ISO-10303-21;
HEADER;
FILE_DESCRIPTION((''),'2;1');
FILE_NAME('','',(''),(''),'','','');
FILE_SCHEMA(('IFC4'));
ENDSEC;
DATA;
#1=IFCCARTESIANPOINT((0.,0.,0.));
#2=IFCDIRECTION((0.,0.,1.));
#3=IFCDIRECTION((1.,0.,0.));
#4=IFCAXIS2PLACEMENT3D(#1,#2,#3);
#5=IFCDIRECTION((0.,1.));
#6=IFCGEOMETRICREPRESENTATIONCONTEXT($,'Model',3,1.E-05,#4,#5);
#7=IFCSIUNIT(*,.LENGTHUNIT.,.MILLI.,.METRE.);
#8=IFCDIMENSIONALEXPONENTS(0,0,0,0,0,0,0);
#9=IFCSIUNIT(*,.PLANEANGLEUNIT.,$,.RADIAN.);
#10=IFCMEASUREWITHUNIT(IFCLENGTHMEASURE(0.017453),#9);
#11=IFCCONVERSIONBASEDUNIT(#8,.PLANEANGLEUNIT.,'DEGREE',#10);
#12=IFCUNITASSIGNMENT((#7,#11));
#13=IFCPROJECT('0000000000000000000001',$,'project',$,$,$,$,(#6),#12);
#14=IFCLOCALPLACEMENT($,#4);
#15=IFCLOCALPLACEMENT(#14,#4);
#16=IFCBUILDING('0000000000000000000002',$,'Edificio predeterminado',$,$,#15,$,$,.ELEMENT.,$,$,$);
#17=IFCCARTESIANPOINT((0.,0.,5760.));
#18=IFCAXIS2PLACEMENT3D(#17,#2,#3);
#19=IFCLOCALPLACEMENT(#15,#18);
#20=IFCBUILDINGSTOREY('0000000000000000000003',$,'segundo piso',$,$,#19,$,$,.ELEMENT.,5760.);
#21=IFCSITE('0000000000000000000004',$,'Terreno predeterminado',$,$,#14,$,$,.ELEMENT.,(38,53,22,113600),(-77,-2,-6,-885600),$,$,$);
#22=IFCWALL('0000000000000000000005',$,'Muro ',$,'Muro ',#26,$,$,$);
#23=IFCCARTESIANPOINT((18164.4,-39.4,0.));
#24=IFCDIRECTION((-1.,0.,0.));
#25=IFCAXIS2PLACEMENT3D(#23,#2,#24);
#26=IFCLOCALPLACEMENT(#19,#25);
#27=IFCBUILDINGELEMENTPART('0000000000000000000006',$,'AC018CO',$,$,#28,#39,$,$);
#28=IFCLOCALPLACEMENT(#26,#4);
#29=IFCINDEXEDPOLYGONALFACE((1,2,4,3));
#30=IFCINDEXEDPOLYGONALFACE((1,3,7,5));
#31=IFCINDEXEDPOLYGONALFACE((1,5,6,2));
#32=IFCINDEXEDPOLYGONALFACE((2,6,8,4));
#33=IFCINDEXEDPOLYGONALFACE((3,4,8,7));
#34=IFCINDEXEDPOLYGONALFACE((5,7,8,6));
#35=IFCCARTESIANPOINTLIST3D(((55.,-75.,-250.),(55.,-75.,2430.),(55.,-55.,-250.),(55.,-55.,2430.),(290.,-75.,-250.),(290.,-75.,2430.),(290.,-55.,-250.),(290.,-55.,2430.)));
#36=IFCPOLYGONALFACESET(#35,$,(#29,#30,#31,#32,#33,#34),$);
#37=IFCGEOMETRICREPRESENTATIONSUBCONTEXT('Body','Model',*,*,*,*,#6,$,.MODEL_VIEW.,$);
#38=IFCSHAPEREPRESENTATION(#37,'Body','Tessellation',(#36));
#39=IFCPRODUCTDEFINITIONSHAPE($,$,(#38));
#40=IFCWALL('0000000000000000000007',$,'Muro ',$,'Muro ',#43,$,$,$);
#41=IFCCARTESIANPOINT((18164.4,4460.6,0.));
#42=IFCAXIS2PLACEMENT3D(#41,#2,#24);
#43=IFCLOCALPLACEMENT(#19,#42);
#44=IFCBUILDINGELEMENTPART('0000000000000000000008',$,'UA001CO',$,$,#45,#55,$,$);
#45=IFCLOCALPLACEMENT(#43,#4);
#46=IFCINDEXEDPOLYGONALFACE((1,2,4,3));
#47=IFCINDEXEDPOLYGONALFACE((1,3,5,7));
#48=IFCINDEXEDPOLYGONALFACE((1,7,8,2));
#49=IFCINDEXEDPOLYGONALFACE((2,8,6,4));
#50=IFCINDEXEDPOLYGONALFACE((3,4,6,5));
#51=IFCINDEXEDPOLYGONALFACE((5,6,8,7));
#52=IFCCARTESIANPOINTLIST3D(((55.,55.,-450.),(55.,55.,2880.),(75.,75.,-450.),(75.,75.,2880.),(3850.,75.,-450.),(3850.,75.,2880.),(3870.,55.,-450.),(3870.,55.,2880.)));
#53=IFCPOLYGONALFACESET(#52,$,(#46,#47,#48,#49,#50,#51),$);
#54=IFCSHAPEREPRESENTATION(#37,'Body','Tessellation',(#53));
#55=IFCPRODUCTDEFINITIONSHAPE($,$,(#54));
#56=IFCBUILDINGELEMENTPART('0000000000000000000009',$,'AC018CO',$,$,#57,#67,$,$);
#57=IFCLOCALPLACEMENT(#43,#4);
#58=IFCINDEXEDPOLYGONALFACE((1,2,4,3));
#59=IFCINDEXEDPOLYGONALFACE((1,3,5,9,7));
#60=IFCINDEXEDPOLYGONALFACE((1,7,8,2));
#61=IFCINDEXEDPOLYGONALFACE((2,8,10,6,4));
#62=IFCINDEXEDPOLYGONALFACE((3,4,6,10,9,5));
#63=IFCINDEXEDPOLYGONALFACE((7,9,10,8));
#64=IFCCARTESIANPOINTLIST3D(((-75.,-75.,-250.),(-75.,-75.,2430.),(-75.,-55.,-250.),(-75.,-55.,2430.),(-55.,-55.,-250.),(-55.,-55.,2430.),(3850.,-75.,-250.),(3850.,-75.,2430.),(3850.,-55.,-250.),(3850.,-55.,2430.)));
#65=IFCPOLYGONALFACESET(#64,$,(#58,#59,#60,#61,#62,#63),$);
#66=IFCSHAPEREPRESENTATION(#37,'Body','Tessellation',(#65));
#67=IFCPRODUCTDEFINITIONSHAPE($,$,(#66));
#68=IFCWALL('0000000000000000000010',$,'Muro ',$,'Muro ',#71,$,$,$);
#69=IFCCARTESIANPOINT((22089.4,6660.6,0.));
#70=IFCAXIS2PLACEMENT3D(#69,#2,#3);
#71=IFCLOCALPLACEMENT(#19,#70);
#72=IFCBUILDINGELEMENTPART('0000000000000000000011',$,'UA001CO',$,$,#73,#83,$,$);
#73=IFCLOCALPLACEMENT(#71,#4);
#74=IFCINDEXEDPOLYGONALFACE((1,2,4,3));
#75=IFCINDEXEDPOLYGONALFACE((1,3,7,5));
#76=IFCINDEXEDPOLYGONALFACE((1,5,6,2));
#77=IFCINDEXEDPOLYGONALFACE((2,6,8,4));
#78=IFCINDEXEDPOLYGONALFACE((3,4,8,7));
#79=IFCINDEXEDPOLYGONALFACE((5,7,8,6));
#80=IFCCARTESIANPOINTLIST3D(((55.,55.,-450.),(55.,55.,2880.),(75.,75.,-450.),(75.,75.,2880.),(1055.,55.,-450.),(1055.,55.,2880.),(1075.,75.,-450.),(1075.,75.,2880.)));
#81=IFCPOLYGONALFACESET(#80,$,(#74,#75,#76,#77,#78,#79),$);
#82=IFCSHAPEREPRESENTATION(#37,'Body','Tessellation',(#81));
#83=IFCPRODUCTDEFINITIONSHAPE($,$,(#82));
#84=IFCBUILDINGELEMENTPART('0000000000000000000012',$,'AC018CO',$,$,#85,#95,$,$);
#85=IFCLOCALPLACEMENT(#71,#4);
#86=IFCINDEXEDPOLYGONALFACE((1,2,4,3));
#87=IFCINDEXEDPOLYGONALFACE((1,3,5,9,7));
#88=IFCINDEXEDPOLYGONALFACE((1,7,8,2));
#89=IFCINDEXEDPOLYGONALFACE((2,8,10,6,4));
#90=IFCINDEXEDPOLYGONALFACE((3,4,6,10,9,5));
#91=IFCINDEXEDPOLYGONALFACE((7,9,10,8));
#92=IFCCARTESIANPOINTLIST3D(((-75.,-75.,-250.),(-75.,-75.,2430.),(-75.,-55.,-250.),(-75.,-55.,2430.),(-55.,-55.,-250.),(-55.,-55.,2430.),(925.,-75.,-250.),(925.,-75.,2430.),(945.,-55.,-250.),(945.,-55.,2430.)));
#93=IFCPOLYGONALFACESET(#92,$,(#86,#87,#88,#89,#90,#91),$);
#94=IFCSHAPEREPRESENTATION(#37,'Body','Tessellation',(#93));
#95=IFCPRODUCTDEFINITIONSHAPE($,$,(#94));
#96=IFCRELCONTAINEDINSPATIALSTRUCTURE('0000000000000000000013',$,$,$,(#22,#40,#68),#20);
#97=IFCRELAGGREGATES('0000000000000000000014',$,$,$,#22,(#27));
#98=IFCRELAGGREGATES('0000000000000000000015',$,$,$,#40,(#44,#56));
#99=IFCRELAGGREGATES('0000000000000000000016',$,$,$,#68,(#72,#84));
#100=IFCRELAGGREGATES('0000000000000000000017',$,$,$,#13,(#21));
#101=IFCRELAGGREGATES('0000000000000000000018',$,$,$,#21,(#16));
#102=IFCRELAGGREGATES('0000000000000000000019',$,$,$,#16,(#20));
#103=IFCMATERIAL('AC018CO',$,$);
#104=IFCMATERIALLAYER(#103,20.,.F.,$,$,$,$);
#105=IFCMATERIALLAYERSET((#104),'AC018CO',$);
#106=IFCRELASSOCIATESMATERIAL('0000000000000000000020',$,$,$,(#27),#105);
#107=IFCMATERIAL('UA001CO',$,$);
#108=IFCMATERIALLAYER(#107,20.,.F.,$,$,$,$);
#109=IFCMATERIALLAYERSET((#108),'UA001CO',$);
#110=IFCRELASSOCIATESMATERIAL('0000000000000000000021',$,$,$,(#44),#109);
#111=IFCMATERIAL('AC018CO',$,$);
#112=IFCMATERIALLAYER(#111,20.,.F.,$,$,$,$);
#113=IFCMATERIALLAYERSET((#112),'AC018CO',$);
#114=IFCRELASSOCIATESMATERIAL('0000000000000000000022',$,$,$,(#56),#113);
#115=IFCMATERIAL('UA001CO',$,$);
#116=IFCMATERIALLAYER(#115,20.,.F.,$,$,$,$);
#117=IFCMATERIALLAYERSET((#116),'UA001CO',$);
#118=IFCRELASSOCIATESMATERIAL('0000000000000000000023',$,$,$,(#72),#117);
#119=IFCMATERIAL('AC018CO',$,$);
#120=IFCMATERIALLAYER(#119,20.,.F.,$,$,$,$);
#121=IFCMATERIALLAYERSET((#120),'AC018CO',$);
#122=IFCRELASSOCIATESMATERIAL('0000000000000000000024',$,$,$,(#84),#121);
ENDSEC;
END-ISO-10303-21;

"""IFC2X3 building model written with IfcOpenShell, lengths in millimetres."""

from ifc_helpers import new_model, entity, si_unit, converted_unit, direction, frame, origin_with_axes, place, context, subcontext, project, spatial, polyline, outline, extrude, material, layer, layer_set, layer_usage, element, aggregate, save


model = new_model("IFC2X3")

# Units and contexts
model_context = context("Model", 3, precision=1e-05, world=origin_with_axes(), true_north=direction((0.0, 1.0)))
body_context = subcontext(model_context, "Body", "Model", "MODEL_VIEW")
ifc_project = project(units=[si_unit("LENGTHUNIT", "METRE", prefix="MILLI"), converted_unit("PLANEANGLEUNIT", "DEGREE", entity("IfcLengthMeasure", 0.017453), si_unit("PLANEANGLEUNIT", "RADIAN"), dimensions=[0, 0, 0, 0, 0, 0, 0])], contexts=[model_context])

# Site, building, storey
site_placement = place(None, origin_with_axes())
site = spatial("IfcSite", under=ifc_project, at=site_placement, Name="Terreno predeterminado", CompositionType="ELEMENT", RefLatitude=(38, 53, 22, 113600), RefLongitude=(-77, -2, -6, -885600))
building_placement = place(site_placement, origin_with_axes())
building = spatial("IfcBuilding", under=site, at=building_placement, Name="Edificio predeterminado", CompositionType="ELEMENT")
storey_placement = place(building_placement, frame((0.0, 0.0, 5760.0), z_axis=(0.0, 0.0, 1.0), x_axis=(1.0, 0.0, 0.0)))
storey = spatial("IfcBuildingStorey", under=building, at=storey_placement, Name="segundo piso", CompositionType="ELEMENT", Elevation=5760.0)

# Wall, building element part
wall_1_placement = place(storey_placement, frame((18164.4, -39.4, 0.0), z_axis=(0.0, 0.0, 1.0), x_axis=(-1.0, 0.0, 0.0)))
wall_1 = element("IfcWall", 1, at=wall_1_placement, inside=storey, Name="Muro ", ObjectType="Muro ")
ifc_material_1 = material(Name="AC018CO")
ifc_layer_1 = layer(ifc_material_1, 20.0, ventilated=False)
ifc_layer_set_1 = layer_set([ifc_layer_1], Name="AC018CO")
ifc_layer_usage_1 = layer_usage(ifc_layer_set_1, "AXIS2", "NEGATIVE", 55.0)
building_element_part_1_placement = place(wall_1_placement, origin_with_axes())
building_element_part_1 = element("IfcBuildingElementPart", 2, at=building_element_part_1_placement, material=ifc_layer_usage_1, Name="AC018CO", context=body_context, shape_type="SweptSolid", body=[
    extrude(outline(polyline([(290.0, -55.0), (290.0, -75.0), (55.0, -75.0), (55.0, -55.0), (290.0, -55.0)])), frame((0.0, 0.0, -250.0), z_axis=(0.0, 0.0, 1.0), x_axis=(1.0, 0.0, 0.0)), (0.0, 0.0, 1.0), 2680.0),
])
aggregate(wall_1, [building_element_part_1])

# Walls, building element parts
wall_2_placement = place(storey_placement, frame((18164.4, 4460.6, 0.0), z_axis=(0.0, 0.0, 1.0), x_axis=(-1.0, 0.0, 0.0)))
wall_2 = element("IfcWall", 3, at=wall_2_placement, inside=storey, Name="Muro ", ObjectType="Muro ")
ifc_material_2 = material(Name="UA001CO")
ifc_layer_2 = layer(ifc_material_2, 20.0, ventilated=False)
ifc_layer_set_2 = layer_set([ifc_layer_2], Name="UA001CO")
ifc_layer_usage_2 = layer_usage(ifc_layer_set_2, "AXIS2", "NEGATIVE", -75.0)
building_element_part_2_placement = place(wall_2_placement, origin_with_axes())
building_element_part_2 = element("IfcBuildingElementPart", 4, at=building_element_part_2_placement, material=ifc_layer_usage_2, Name="UA001CO", context=body_context, shape_type="SweptSolid", body=[
    extrude(outline(polyline([(3850.0, 75.0), (3870.0, 55.0), (55.0, 55.0), (75.0, 75.0), (3850.0, 75.0)])), frame((0.0, 0.0, -450.0), z_axis=(0.0, 0.0, 1.0), x_axis=(1.0, 0.0, 0.0)), (0.0, 0.0, 1.0), 3330.0),
])
ifc_material_3 = material(Name="AC018CO")
ifc_layer_3 = layer(ifc_material_3, 20.0, ventilated=False)
ifc_layer_set_3 = layer_set([ifc_layer_3], Name="AC018CO")
ifc_layer_usage_3 = layer_usage(ifc_layer_set_3, "AXIS2", "NEGATIVE", 55.0)
building_element_part_3_placement = place(wall_2_placement, origin_with_axes())
building_element_part_3 = element("IfcBuildingElementPart", 5, at=building_element_part_3_placement, material=ifc_layer_usage_3, Name="AC018CO", context=body_context, shape_type="SweptSolid", body=[
    extrude(outline(polyline([(3850.0, -55.0), (3850.0, -75.0), (-75.0, -75.0), (-75.0, -55.0), (-55.0, -55.0), (3850.0, -55.0)])), frame((0.0, 0.0, -250.0), z_axis=(0.0, 0.0, 1.0), x_axis=(1.0, 0.0, 0.0)), (0.0, 0.0, 1.0), 2680.0),
])
aggregate(wall_2, [building_element_part_2, building_element_part_3])
wall_3_placement = place(storey_placement, frame((22089.4, 6660.6, 0.0), z_axis=(0.0, 0.0, 1.0), x_axis=(1.0, 0.0, 0.0)))
wall_3 = element("IfcWall", 6, at=wall_3_placement, inside=storey, Name="Muro ", ObjectType="Muro ")
ifc_material_4 = material(Name="UA001CO")
ifc_layer_4 = layer(ifc_material_4, 20.0, ventilated=False)
ifc_layer_set_4 = layer_set([ifc_layer_4], Name="UA001CO")
ifc_layer_usage_4 = layer_usage(ifc_layer_set_4, "AXIS2", "NEGATIVE", -75.0)
building_element_part_4_placement = place(wall_3_placement, origin_with_axes())
building_element_part_4 = element("IfcBuildingElementPart", 7, at=building_element_part_4_placement, material=ifc_layer_usage_4, Name="UA001CO", context=body_context, shape_type="SweptSolid", body=[
    extrude(outline(polyline([(1075.0, 75.0), (1055.0, 55.0), (55.0, 55.0), (75.0, 75.0), (1075.0, 75.0)])), frame((0.0, 0.0, -450.0), z_axis=(0.0, 0.0, 1.0), x_axis=(1.0, 0.0, 0.0)), (0.0, 0.0, 1.0), 3330.0),
])
ifc_material_5 = material(Name="AC018CO")
ifc_layer_5 = layer(ifc_material_5, 20.0, ventilated=False)
ifc_layer_set_5 = layer_set([ifc_layer_5], Name="AC018CO")
ifc_layer_usage_5 = layer_usage(ifc_layer_set_5, "AXIS2", "NEGATIVE", 55.0)
building_element_part_5_placement = place(wall_3_placement, origin_with_axes())
building_element_part_5 = element("IfcBuildingElementPart", 8, at=building_element_part_5_placement, material=ifc_layer_usage_5, Name="AC018CO", context=body_context, shape_type="SweptSolid", body=[
    extrude(outline(polyline([(945.0, -55.0), (925.0, -75.0), (-75.0, -75.0), (-75.0, -55.0), (-55.0, -55.0), (945.0, -55.0)])), frame((0.0, 0.0, -250.0), z_axis=(0.0, 0.0, 1.0), x_axis=(1.0, 0.0, 0.0)), (0.0, 0.0, 1.0), 2680.0),
])
aggregate(wall_3, [building_element_part_4, building_element_part_5])

save(model, "model.ifc")
